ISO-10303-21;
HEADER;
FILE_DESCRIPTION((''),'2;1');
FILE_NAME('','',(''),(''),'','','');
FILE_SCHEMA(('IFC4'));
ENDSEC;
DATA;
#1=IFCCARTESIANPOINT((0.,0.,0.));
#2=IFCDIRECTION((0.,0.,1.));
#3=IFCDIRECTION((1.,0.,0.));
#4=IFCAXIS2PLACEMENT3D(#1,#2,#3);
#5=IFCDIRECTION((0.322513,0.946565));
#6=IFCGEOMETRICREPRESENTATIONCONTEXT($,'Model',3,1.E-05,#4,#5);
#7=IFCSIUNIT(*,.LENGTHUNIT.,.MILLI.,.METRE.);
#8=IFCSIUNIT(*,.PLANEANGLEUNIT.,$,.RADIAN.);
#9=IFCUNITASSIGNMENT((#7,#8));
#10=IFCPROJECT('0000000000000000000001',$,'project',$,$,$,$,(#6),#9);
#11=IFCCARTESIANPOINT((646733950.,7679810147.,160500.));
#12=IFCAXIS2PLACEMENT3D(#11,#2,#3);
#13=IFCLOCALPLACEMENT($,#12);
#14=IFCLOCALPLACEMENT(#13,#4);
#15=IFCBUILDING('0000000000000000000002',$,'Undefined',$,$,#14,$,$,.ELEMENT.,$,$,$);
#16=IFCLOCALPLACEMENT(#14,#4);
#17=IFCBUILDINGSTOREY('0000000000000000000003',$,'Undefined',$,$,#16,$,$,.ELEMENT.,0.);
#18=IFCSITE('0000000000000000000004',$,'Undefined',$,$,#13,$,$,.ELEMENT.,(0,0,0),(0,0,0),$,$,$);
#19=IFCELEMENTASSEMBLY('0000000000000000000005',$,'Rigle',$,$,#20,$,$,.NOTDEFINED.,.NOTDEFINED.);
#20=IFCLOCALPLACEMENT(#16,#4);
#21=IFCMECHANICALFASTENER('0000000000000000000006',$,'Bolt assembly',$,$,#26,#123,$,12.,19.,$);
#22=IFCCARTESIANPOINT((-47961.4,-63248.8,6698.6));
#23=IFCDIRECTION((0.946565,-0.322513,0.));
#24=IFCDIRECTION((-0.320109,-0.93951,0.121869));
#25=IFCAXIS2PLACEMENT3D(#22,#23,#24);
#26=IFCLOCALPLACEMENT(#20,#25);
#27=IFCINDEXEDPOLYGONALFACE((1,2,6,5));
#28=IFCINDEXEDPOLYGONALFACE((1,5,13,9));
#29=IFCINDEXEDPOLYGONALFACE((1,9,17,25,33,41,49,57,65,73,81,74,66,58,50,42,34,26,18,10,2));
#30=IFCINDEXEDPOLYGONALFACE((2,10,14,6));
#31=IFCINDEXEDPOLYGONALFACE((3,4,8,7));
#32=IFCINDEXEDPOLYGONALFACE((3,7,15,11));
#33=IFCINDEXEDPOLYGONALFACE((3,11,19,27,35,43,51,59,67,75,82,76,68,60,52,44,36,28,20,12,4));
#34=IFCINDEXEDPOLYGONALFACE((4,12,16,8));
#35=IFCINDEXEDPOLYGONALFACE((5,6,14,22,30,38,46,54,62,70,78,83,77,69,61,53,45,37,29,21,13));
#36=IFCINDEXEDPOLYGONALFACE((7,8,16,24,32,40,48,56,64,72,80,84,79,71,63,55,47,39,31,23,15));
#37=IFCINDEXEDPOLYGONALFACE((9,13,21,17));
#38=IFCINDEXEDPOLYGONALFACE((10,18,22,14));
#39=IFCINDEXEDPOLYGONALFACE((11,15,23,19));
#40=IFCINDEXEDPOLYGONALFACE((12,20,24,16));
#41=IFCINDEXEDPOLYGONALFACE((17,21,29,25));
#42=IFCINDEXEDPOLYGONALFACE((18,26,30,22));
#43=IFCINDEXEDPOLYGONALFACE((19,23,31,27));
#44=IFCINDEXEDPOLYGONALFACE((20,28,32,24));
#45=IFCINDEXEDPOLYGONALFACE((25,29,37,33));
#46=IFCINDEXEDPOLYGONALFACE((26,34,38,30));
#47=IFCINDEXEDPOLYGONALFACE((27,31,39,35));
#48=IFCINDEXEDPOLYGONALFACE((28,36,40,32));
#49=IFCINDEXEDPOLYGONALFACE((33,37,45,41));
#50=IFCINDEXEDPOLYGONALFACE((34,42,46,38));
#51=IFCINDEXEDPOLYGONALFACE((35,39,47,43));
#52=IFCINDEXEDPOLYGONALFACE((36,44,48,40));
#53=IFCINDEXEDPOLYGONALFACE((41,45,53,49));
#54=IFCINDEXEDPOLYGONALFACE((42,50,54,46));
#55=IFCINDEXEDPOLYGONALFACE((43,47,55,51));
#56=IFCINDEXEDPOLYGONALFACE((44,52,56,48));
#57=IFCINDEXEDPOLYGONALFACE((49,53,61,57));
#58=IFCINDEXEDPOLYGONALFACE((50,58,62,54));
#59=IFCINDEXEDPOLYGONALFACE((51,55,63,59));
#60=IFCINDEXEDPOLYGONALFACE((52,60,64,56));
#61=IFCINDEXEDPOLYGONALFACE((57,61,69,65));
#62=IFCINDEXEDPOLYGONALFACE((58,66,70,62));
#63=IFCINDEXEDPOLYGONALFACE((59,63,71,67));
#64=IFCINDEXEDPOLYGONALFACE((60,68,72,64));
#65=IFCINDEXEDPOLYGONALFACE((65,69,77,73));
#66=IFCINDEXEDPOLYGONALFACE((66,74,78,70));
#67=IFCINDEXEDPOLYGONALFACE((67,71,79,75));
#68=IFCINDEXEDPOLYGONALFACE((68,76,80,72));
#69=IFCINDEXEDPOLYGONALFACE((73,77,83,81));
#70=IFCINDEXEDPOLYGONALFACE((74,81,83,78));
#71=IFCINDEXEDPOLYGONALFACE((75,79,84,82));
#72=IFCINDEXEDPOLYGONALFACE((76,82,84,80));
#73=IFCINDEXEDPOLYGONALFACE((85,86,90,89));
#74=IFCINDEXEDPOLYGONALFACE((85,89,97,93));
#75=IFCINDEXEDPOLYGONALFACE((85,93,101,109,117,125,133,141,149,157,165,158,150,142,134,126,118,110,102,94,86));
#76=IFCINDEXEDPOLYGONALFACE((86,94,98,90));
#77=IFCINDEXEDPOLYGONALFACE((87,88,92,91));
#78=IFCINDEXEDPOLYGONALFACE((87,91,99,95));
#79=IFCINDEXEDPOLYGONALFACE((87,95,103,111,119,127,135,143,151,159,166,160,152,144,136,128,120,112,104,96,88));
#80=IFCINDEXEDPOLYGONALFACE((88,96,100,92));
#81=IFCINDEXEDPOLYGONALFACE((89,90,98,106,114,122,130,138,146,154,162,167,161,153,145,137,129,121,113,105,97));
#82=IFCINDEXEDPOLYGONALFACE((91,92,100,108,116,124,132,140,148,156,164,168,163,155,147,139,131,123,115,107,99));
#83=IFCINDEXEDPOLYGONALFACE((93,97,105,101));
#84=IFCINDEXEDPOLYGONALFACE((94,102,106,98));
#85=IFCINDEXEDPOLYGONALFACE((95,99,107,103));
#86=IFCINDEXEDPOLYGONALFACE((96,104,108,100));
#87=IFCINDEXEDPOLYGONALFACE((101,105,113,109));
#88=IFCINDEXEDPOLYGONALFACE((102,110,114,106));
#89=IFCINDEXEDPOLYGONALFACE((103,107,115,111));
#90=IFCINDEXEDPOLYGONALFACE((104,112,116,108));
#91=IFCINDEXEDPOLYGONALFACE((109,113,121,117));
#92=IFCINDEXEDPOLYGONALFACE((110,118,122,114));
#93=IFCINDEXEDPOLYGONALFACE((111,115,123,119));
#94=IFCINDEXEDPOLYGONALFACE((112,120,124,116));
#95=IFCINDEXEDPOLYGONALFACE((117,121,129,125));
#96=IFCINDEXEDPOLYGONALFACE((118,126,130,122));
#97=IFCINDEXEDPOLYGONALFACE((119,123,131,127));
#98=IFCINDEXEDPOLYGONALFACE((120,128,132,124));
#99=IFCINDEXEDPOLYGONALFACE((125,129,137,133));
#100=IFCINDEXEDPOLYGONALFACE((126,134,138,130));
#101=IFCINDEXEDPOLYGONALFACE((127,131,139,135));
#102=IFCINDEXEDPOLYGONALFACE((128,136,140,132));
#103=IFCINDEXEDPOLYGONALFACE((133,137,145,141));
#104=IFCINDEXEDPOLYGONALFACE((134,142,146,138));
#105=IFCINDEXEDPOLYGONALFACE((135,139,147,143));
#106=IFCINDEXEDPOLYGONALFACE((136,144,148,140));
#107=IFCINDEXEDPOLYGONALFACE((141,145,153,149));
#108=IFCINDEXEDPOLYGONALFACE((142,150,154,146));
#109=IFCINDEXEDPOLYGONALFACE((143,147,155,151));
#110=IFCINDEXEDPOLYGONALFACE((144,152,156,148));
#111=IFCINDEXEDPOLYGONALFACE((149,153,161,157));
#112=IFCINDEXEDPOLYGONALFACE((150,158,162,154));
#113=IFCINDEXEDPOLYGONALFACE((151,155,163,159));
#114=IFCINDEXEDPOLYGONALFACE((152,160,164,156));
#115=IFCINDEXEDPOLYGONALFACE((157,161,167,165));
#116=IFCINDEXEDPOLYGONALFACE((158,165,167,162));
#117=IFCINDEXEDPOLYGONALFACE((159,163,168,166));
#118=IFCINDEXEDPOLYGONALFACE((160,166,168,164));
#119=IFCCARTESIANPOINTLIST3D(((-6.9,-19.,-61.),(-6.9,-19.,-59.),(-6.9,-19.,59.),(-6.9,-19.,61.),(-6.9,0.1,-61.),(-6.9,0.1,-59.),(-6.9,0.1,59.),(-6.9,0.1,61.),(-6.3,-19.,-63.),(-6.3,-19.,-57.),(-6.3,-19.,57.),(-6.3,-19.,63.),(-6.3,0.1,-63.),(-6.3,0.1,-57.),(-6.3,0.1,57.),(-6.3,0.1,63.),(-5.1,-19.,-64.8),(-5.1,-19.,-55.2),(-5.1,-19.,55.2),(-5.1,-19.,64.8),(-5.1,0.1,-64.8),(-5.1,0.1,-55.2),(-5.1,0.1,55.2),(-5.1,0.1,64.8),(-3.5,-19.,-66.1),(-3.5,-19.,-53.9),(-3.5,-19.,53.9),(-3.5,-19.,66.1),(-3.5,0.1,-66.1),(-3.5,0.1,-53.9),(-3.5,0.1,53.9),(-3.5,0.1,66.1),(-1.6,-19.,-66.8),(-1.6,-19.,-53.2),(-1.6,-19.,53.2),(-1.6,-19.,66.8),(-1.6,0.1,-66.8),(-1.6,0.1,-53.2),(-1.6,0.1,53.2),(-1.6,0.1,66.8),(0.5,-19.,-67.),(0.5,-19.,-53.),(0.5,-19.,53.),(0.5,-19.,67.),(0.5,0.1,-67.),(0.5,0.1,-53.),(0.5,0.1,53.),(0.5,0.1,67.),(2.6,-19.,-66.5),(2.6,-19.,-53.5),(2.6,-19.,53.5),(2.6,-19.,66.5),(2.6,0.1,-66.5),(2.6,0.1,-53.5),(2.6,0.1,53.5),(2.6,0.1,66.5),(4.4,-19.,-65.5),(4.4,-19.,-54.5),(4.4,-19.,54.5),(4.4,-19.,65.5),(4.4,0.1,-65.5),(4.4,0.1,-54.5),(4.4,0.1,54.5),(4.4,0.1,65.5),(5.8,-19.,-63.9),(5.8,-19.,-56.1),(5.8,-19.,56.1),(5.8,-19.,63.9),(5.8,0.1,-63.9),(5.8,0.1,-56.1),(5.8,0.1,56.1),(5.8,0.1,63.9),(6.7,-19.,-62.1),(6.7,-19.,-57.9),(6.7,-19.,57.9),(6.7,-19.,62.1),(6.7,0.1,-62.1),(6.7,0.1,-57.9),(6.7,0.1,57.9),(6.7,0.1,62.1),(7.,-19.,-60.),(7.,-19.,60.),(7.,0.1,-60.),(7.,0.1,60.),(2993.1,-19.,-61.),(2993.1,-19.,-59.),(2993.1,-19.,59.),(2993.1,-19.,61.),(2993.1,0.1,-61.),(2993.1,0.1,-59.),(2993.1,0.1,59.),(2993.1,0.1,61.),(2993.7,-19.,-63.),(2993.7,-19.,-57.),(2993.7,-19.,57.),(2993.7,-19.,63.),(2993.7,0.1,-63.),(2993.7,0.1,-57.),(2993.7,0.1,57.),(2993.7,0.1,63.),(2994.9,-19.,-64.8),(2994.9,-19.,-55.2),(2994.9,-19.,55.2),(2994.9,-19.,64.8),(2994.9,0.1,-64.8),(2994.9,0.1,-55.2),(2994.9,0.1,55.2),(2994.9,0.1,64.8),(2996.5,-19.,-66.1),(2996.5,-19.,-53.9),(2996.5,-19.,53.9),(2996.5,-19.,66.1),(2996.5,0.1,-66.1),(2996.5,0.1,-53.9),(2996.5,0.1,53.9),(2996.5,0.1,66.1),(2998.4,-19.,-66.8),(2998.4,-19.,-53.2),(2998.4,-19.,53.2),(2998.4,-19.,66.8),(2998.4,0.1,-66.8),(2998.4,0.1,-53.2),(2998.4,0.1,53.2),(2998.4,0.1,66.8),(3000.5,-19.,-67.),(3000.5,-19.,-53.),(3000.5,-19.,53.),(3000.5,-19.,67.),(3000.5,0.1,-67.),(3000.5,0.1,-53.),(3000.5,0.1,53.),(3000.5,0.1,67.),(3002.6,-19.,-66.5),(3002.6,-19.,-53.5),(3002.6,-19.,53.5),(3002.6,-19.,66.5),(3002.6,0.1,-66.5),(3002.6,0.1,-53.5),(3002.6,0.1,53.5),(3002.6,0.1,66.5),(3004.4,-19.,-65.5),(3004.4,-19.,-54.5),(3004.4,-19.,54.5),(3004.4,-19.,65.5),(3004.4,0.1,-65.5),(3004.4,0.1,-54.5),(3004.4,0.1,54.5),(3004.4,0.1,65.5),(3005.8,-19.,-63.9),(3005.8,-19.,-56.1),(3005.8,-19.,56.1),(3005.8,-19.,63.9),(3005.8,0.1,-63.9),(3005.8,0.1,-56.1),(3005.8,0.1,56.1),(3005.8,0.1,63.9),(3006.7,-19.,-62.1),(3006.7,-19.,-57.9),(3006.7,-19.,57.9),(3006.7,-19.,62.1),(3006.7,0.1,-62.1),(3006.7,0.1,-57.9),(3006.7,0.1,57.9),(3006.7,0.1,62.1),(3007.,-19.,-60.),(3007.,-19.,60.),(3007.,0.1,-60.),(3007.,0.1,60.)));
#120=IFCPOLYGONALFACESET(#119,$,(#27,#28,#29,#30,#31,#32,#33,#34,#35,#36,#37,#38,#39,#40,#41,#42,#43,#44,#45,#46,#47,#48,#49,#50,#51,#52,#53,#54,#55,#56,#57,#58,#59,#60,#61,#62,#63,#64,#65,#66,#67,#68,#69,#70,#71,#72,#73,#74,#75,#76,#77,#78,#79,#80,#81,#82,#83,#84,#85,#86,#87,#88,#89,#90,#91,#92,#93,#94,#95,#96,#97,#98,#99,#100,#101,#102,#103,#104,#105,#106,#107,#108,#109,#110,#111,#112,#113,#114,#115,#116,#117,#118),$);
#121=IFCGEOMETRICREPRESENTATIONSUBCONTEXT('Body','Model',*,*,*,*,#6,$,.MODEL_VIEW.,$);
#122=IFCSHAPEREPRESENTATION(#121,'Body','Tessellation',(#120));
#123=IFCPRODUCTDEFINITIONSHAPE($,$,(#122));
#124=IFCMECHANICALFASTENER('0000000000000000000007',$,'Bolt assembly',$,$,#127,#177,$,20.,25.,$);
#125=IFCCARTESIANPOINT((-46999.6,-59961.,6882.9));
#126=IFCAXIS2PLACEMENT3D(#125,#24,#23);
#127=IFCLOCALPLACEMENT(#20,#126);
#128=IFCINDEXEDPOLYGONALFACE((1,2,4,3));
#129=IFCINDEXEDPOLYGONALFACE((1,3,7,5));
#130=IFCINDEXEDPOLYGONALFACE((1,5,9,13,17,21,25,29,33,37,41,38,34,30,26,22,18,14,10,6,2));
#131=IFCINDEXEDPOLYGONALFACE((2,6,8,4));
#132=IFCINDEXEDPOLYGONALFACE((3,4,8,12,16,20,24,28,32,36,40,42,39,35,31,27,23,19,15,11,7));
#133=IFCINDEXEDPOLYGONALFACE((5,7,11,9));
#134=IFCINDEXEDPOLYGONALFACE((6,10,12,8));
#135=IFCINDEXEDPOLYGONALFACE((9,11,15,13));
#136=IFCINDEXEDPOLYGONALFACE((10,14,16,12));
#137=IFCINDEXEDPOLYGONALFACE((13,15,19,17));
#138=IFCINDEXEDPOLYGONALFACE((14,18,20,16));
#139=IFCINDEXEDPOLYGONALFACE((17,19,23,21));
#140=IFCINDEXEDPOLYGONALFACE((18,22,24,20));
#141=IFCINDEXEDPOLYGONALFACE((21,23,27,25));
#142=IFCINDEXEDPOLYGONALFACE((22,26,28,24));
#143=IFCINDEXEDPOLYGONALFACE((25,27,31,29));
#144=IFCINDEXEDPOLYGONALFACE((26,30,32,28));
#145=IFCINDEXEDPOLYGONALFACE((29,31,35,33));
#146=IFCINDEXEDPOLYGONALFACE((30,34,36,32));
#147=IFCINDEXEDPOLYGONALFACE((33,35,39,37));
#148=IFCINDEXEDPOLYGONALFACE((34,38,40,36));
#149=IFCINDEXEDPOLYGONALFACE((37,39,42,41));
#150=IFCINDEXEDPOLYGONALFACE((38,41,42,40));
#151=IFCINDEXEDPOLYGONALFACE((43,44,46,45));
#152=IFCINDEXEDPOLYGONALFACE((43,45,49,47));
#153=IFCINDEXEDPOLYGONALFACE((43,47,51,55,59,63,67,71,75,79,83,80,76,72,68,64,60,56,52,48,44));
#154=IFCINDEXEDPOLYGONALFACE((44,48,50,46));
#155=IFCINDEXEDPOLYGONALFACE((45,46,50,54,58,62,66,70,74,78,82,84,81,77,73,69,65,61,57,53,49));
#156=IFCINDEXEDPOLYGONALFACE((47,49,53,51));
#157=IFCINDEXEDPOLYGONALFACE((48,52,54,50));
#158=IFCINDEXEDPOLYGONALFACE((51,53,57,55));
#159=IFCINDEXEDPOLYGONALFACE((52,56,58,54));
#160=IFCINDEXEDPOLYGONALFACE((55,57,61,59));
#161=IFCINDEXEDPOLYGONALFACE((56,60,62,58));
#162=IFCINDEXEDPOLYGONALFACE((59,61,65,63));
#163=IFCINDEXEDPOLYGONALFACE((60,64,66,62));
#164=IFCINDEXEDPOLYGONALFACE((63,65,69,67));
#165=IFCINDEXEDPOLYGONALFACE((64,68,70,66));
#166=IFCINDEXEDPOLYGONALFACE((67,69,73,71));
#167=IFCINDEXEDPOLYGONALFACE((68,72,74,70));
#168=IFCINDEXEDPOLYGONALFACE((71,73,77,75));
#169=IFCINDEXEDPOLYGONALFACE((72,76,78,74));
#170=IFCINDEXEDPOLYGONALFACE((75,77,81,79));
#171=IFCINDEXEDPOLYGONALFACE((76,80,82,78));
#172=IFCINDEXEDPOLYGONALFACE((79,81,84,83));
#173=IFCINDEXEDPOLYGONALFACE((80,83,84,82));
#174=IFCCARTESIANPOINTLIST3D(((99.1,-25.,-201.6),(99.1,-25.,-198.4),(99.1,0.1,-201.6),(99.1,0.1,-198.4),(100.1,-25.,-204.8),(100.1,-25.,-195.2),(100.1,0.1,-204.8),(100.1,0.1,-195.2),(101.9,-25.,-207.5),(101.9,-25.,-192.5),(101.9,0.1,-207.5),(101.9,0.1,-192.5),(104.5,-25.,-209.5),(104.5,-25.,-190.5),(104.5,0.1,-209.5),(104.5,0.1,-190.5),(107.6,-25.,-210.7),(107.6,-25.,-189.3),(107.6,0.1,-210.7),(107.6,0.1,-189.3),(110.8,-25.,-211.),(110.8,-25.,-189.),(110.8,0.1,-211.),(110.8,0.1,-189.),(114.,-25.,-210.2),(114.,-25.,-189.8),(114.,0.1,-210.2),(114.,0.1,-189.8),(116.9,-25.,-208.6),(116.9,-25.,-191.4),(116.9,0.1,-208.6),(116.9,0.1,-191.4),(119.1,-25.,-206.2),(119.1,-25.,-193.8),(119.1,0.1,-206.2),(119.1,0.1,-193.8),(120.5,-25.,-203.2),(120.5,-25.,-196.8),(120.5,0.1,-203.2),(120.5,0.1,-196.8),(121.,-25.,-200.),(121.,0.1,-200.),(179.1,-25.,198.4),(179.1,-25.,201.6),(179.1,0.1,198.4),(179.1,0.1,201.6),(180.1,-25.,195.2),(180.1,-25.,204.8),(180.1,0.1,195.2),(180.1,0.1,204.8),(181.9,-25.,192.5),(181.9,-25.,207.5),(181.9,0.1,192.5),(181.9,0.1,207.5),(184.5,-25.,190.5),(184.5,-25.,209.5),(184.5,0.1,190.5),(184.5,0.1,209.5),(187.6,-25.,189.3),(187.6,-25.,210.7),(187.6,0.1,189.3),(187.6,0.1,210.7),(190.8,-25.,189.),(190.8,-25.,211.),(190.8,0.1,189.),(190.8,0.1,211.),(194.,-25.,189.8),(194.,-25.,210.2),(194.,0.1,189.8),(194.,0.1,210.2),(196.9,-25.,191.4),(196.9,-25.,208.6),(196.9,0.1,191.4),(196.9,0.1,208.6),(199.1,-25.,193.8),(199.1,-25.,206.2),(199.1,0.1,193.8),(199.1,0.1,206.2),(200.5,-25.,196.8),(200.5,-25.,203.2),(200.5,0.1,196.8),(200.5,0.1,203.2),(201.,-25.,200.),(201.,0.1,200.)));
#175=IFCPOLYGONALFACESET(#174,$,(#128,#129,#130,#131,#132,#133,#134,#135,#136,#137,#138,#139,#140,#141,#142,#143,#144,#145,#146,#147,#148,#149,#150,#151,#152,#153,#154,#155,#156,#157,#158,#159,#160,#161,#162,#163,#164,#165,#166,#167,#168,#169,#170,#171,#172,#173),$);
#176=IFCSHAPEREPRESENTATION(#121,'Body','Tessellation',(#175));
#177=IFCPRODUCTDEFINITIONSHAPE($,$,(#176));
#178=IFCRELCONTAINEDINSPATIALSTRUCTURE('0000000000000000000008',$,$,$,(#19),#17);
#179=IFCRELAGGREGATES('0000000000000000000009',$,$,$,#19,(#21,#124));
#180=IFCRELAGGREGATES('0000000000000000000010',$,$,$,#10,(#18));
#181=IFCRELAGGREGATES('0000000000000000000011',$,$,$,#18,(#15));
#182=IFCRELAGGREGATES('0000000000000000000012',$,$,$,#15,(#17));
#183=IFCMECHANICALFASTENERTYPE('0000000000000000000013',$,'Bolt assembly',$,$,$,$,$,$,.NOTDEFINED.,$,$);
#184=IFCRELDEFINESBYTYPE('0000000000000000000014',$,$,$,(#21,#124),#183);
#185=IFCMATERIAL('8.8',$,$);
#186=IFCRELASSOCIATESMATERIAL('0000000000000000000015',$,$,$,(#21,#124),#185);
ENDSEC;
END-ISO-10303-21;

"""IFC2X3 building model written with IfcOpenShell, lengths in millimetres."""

from ifc_helpers import new_model, si_unit, direction, frame, origin_with_axes, origin_2d_with_axis, place, context, subcontext, project, spatial, circle, extrude, source, transform, mapped, material, type_object, element, aggregate, save


model = new_model("IFC2X3")

# Units and contexts
model_context = context("Model", 3, precision=1e-05, world=origin_with_axes(), true_north=direction((0.322513, 0.946565)))
body_context = subcontext(model_context, "Body", "Model", "MODEL_VIEW")
ifc_project = project(units=[si_unit("LENGTHUNIT", "METRE", prefix="MILLI"), si_unit("PLANEANGLEUNIT", "RADIAN")], contexts=[model_context])

# Site, building, storey
site_placement = place(None, frame((646733950.0, 7679810147.0, 160500.0), z_axis=(0.0, 0.0, 1.0), x_axis=(1.0, 0.0, 0.0)))
site = spatial("IfcSite", under=ifc_project, at=site_placement, Name="Undefined", CompositionType="ELEMENT", RefLatitude=(0, 0, 0), RefLongitude=(0, 0, 0))
building_placement = place(site_placement, origin_with_axes())
building = spatial("IfcBuilding", under=site, at=building_placement, Name="Undefined", CompositionType="ELEMENT")
storey_placement = place(building_placement, origin_with_axes())
storey = spatial("IfcBuildingStorey", under=building, at=storey_placement, Name="Undefined", CompositionType="ELEMENT", Elevation=0.0)

# Element assembly
assembly_1_placement = place(storey_placement, origin_with_axes())
assembly_1 = element("IfcElementAssembly", 1, at=assembly_1_placement, inside=storey, Name="Rigle", AssemblyPlace="NOTDEFINED", PredefinedType="NOTDEFINED")

# Mechanical fasteners
ifc_material_1 = material(Name="8.8")
mechanical_fastener_type = type_object("IfcMechanicalFastenerType", Name="Bolt assembly")
shared_shape_1 = source(origin_with_axes(), body_context, "Body", "SweptSolid", [
    extrude(circle(Radius=7.0, at=origin_2d_with_axis()), frame((0.0, -19.0, 0.0), z_axis=(0.0, 1.0, 0.0), x_axis=(1.0, 0.0, 0.0)), (0.0, 0.0, 1.0), 19.1),
])
mechanical_fastener_1_placement = place(assembly_1_placement, frame((-47961.4, -63248.8, 6698.6), z_axis=(0.946565, -0.322513, 0.0), x_axis=(-0.320109, -0.93951, 0.121869)))
mechanical_fastener_1 = element("IfcMechanicalFastener", 2, at=mechanical_fastener_1_placement, type_object=mechanical_fastener_type, material=ifc_material_1, Name="Bolt assembly", NominalDiameter=12.0, NominalLength=19.0, context=body_context, shape_type="MappedRepresentation", body=[
    mapped(shared_shape_1, transform((0.0, 0.0, -60.0))),
    mapped(shared_shape_1, transform((3000.0, 0.0, -60.0))),
    mapped(shared_shape_1, transform((0.0, 0.0, 60.0))),
    mapped(shared_shape_1, transform((3000.0, 0.0, 60.0))),
])
shared_shape_2 = source(origin_with_axes(), body_context, "Body", "SweptSolid", [
    extrude(circle(Radius=11.0, at=origin_2d_with_axis()), frame((0.0, -25.0, 0.0), z_axis=(0.0, 1.0, 0.0), x_axis=(1.0, 0.0, 0.0)), (0.0, 0.0, 1.0), 25.1),
])
mechanical_fastener_2_placement = place(assembly_1_placement, frame((-46999.6, -59961.0, 6882.9), z_axis=(-0.320109, -0.93951, 0.121869), x_axis=(0.946565, -0.322513, 0.0)))
mechanical_fastener_2 = element("IfcMechanicalFastener", 3, at=mechanical_fastener_2_placement, type_object=mechanical_fastener_type, material=ifc_material_1, Name="Bolt assembly", NominalDiameter=20.0, NominalLength=25.0, context=body_context, shape_type="MappedRepresentation", body=[
    mapped(shared_shape_2, transform((110.0, 0.0, -200.0))),
    mapped(shared_shape_2, transform((190.0, 0.0, 200.0))),
])

aggregate(assembly_1, [mechanical_fastener_1, mechanical_fastener_2])

save(model, "model.ifc")
